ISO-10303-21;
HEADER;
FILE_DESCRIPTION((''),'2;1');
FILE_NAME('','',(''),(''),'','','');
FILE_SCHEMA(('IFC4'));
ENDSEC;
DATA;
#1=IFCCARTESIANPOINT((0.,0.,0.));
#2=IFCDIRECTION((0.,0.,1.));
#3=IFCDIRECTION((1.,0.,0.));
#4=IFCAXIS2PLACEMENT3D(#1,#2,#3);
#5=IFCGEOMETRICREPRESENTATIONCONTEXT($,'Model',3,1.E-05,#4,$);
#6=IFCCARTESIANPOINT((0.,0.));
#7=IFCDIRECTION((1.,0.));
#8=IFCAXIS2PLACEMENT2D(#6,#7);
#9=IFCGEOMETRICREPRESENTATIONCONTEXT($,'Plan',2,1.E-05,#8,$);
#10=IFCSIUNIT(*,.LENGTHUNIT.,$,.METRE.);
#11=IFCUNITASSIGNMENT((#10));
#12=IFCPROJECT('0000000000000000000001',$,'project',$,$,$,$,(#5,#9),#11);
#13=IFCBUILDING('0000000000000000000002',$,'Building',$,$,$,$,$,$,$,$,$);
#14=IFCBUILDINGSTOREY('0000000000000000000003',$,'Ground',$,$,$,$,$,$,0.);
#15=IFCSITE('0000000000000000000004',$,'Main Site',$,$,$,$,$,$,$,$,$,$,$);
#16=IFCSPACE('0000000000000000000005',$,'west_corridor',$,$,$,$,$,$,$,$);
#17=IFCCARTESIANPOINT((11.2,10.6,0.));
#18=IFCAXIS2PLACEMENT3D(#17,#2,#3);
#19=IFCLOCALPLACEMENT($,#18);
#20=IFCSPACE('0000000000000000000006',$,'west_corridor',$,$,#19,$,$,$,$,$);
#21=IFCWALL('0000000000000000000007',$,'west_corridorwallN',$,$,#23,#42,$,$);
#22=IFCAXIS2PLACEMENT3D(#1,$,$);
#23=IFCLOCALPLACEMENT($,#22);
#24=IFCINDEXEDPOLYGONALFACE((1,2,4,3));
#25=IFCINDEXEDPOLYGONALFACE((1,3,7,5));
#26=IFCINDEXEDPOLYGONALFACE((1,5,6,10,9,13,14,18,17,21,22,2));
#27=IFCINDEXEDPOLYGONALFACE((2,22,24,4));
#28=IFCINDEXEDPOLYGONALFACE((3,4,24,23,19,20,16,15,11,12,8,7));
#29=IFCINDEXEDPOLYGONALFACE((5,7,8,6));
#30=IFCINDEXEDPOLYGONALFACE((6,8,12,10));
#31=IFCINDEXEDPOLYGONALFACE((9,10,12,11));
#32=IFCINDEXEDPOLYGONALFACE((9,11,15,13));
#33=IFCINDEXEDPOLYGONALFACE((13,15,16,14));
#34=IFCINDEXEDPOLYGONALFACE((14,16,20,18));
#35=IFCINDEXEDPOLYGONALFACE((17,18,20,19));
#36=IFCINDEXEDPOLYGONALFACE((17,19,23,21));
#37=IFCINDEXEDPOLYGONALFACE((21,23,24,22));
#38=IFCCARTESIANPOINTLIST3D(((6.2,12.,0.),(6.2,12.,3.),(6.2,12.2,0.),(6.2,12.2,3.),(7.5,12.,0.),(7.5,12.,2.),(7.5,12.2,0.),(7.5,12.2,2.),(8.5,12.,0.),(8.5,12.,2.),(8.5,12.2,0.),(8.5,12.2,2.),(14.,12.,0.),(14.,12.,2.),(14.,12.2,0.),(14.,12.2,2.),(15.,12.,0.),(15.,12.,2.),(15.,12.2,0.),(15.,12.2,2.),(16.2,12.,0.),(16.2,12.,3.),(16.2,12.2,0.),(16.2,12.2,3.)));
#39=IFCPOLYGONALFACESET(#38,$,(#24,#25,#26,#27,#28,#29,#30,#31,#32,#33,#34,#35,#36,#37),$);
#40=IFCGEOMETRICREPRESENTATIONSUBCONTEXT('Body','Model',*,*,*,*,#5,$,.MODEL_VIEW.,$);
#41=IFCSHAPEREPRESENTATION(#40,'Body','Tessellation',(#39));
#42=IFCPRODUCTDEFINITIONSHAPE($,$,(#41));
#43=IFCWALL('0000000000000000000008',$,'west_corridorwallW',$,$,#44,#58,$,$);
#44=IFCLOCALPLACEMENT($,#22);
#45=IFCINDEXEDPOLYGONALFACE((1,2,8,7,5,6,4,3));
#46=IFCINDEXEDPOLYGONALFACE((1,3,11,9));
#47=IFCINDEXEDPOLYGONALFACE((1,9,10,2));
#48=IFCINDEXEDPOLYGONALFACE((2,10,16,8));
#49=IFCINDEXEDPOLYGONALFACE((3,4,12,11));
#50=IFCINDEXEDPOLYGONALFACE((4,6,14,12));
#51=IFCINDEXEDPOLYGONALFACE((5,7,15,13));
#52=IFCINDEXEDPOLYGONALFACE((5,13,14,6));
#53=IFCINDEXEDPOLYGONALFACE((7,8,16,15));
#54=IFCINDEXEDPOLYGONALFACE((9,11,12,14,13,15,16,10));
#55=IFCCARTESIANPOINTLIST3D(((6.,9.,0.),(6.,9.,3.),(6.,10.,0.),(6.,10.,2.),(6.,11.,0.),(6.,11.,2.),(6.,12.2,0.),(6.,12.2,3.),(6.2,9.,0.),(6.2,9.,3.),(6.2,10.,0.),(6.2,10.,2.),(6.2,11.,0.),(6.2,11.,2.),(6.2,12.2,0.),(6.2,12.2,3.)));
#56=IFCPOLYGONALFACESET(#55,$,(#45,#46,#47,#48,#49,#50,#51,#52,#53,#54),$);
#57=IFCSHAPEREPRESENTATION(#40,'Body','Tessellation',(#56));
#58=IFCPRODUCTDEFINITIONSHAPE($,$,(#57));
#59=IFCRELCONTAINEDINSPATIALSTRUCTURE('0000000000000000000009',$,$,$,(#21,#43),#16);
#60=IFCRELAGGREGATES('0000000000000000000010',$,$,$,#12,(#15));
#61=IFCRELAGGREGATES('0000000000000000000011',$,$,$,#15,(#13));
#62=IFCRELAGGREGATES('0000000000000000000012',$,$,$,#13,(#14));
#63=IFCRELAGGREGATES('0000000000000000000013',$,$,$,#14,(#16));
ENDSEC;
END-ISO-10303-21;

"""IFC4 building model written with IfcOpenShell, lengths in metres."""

from ifc_helpers import new_model, si_unit, frame, origin_with_axes, origin_2d_with_axis, place, context, subcontext, project, spatial, indexed_curve, outline, extrude, element, save


model = new_model("IFC4")

# Units and contexts
model_context = context("Model", 3, precision=1e-05, world=origin_with_axes())
plan_context = context("Plan", 2, precision=1e-05, world=origin_2d_with_axis())
body_context = subcontext(model_context, "Body", "Model", "MODEL_VIEW")
ifc_project = project(units=[si_unit("LENGTHUNIT", "METRE")], contexts=[model_context, plan_context])

# Site, building, storey
site = spatial("IfcSite", under=ifc_project, Name="Main Site")
building = spatial("IfcBuilding", under=site, Name="Building")
storey = spatial("IfcBuildingStorey", under=building, Name="Ground", Elevation=0.0)

# Shared definitions
space_1 = spatial("IfcSpace", under=storey, Name="west_corridor")

# Wall
wall_1_placement = place(None, frame((6.2, 12.0, 0.0), z_axis=(0.0, 0.0, 1.0), x_axis=(1.0, 0.0, 0.0)))
wall_1 = element("IfcWall", 1, at=wall_1_placement, inside=space_1, Name="west_corridorwallN", context=body_context, shape_type="SweptSolid", body=[
    extrude(outline(indexed_curve([(0.0, 0.0), (0.0, 0.2), (10.0, 0.2), (10.0, 0.0), (0.0, 0.0)], self_intersect=False)), origin_with_axes(), (0.0, 0.0, 1.0), 3.0),
])

# Shared definitions
space_2_placement = place(None, frame((11.2, 10.6, 0.0), z_axis=(0.0, 0.0, 1.0), x_axis=(1.0, 0.0, 0.0)))
space_2 = spatial("IfcSpace", at=space_2_placement, Name="west_corridor")

# Openings
opening_1_placement = place(wall_1_placement, frame((1.3, 0.0, 0.0), z_axis=(0.0, 0.0, 1.0), x_axis=(1.0, 0.0, 0.0)))
element("IfcOpeningElement", 2, at=opening_1_placement, inside=space_2, cuts=wall_1, context=body_context, shape_type="SweptSolid", body=[
    extrude(outline(indexed_curve([(0.0, 0.0), (0.0, 0.4), (1.0, 0.4), (1.0, 0.0), (0.0, 0.0)], self_intersect=False)), origin_with_axes(), (0.0, 0.0, 1.0), 2.0),
])
opening_2_placement = place(wall_1_placement, frame((7.8, 0.0, 0.0), z_axis=(0.0, 0.0, 1.0), x_axis=(1.0, 0.0, 0.0)))
element("IfcOpeningElement", 3, at=opening_2_placement, inside=space_2, cuts=wall_1, context=body_context, shape_type="SweptSolid", body=[
    extrude(outline(indexed_curve([(0.0, 0.0), (0.0, 0.4), (1.0, 0.4), (1.0, 0.0), (0.0, 0.0)], self_intersect=False)), origin_with_axes(), (0.0, 0.0, 1.0), 2.0),
])

# Wall, opening
wall_2_placement = place(None, frame((6.2, 9.0, 0.0), z_axis=(0.0, 0.0, 1.0), x_axis=(0.0, 1.0, 0.0)))
wall_2 = element("IfcWall", 4, at=wall_2_placement, inside=space_1, Name="west_corridorwallW", context=body_context, shape_type="SweptSolid", body=[
    extrude(outline(indexed_curve([(0.0, 0.0), (0.0, 0.2), (3.2, 0.2), (3.2, 0.0), (0.0, 0.0)], self_intersect=False)), origin_with_axes(), (0.0, 0.0, 1.0), 3.0),
])
opening_3_placement = place(wall_2_placement, frame((1.0, 0.0, 0.0), z_axis=(0.0, 0.0, 1.0), x_axis=(1.0, 0.0, 0.0)))
element("IfcOpeningElement", 5, at=opening_3_placement, inside=space_2, cuts=wall_2, context=body_context, shape_type="SweptSolid", body=[
    extrude(outline(indexed_curve([(0.0, 0.0), (0.0, 0.4), (1.0, 0.4), (1.0, 0.0), (0.0, 0.0)], self_intersect=False)), origin_with_axes(), (0.0, 0.0, 1.0), 2.0),
])

save(model, "model.ifc")
